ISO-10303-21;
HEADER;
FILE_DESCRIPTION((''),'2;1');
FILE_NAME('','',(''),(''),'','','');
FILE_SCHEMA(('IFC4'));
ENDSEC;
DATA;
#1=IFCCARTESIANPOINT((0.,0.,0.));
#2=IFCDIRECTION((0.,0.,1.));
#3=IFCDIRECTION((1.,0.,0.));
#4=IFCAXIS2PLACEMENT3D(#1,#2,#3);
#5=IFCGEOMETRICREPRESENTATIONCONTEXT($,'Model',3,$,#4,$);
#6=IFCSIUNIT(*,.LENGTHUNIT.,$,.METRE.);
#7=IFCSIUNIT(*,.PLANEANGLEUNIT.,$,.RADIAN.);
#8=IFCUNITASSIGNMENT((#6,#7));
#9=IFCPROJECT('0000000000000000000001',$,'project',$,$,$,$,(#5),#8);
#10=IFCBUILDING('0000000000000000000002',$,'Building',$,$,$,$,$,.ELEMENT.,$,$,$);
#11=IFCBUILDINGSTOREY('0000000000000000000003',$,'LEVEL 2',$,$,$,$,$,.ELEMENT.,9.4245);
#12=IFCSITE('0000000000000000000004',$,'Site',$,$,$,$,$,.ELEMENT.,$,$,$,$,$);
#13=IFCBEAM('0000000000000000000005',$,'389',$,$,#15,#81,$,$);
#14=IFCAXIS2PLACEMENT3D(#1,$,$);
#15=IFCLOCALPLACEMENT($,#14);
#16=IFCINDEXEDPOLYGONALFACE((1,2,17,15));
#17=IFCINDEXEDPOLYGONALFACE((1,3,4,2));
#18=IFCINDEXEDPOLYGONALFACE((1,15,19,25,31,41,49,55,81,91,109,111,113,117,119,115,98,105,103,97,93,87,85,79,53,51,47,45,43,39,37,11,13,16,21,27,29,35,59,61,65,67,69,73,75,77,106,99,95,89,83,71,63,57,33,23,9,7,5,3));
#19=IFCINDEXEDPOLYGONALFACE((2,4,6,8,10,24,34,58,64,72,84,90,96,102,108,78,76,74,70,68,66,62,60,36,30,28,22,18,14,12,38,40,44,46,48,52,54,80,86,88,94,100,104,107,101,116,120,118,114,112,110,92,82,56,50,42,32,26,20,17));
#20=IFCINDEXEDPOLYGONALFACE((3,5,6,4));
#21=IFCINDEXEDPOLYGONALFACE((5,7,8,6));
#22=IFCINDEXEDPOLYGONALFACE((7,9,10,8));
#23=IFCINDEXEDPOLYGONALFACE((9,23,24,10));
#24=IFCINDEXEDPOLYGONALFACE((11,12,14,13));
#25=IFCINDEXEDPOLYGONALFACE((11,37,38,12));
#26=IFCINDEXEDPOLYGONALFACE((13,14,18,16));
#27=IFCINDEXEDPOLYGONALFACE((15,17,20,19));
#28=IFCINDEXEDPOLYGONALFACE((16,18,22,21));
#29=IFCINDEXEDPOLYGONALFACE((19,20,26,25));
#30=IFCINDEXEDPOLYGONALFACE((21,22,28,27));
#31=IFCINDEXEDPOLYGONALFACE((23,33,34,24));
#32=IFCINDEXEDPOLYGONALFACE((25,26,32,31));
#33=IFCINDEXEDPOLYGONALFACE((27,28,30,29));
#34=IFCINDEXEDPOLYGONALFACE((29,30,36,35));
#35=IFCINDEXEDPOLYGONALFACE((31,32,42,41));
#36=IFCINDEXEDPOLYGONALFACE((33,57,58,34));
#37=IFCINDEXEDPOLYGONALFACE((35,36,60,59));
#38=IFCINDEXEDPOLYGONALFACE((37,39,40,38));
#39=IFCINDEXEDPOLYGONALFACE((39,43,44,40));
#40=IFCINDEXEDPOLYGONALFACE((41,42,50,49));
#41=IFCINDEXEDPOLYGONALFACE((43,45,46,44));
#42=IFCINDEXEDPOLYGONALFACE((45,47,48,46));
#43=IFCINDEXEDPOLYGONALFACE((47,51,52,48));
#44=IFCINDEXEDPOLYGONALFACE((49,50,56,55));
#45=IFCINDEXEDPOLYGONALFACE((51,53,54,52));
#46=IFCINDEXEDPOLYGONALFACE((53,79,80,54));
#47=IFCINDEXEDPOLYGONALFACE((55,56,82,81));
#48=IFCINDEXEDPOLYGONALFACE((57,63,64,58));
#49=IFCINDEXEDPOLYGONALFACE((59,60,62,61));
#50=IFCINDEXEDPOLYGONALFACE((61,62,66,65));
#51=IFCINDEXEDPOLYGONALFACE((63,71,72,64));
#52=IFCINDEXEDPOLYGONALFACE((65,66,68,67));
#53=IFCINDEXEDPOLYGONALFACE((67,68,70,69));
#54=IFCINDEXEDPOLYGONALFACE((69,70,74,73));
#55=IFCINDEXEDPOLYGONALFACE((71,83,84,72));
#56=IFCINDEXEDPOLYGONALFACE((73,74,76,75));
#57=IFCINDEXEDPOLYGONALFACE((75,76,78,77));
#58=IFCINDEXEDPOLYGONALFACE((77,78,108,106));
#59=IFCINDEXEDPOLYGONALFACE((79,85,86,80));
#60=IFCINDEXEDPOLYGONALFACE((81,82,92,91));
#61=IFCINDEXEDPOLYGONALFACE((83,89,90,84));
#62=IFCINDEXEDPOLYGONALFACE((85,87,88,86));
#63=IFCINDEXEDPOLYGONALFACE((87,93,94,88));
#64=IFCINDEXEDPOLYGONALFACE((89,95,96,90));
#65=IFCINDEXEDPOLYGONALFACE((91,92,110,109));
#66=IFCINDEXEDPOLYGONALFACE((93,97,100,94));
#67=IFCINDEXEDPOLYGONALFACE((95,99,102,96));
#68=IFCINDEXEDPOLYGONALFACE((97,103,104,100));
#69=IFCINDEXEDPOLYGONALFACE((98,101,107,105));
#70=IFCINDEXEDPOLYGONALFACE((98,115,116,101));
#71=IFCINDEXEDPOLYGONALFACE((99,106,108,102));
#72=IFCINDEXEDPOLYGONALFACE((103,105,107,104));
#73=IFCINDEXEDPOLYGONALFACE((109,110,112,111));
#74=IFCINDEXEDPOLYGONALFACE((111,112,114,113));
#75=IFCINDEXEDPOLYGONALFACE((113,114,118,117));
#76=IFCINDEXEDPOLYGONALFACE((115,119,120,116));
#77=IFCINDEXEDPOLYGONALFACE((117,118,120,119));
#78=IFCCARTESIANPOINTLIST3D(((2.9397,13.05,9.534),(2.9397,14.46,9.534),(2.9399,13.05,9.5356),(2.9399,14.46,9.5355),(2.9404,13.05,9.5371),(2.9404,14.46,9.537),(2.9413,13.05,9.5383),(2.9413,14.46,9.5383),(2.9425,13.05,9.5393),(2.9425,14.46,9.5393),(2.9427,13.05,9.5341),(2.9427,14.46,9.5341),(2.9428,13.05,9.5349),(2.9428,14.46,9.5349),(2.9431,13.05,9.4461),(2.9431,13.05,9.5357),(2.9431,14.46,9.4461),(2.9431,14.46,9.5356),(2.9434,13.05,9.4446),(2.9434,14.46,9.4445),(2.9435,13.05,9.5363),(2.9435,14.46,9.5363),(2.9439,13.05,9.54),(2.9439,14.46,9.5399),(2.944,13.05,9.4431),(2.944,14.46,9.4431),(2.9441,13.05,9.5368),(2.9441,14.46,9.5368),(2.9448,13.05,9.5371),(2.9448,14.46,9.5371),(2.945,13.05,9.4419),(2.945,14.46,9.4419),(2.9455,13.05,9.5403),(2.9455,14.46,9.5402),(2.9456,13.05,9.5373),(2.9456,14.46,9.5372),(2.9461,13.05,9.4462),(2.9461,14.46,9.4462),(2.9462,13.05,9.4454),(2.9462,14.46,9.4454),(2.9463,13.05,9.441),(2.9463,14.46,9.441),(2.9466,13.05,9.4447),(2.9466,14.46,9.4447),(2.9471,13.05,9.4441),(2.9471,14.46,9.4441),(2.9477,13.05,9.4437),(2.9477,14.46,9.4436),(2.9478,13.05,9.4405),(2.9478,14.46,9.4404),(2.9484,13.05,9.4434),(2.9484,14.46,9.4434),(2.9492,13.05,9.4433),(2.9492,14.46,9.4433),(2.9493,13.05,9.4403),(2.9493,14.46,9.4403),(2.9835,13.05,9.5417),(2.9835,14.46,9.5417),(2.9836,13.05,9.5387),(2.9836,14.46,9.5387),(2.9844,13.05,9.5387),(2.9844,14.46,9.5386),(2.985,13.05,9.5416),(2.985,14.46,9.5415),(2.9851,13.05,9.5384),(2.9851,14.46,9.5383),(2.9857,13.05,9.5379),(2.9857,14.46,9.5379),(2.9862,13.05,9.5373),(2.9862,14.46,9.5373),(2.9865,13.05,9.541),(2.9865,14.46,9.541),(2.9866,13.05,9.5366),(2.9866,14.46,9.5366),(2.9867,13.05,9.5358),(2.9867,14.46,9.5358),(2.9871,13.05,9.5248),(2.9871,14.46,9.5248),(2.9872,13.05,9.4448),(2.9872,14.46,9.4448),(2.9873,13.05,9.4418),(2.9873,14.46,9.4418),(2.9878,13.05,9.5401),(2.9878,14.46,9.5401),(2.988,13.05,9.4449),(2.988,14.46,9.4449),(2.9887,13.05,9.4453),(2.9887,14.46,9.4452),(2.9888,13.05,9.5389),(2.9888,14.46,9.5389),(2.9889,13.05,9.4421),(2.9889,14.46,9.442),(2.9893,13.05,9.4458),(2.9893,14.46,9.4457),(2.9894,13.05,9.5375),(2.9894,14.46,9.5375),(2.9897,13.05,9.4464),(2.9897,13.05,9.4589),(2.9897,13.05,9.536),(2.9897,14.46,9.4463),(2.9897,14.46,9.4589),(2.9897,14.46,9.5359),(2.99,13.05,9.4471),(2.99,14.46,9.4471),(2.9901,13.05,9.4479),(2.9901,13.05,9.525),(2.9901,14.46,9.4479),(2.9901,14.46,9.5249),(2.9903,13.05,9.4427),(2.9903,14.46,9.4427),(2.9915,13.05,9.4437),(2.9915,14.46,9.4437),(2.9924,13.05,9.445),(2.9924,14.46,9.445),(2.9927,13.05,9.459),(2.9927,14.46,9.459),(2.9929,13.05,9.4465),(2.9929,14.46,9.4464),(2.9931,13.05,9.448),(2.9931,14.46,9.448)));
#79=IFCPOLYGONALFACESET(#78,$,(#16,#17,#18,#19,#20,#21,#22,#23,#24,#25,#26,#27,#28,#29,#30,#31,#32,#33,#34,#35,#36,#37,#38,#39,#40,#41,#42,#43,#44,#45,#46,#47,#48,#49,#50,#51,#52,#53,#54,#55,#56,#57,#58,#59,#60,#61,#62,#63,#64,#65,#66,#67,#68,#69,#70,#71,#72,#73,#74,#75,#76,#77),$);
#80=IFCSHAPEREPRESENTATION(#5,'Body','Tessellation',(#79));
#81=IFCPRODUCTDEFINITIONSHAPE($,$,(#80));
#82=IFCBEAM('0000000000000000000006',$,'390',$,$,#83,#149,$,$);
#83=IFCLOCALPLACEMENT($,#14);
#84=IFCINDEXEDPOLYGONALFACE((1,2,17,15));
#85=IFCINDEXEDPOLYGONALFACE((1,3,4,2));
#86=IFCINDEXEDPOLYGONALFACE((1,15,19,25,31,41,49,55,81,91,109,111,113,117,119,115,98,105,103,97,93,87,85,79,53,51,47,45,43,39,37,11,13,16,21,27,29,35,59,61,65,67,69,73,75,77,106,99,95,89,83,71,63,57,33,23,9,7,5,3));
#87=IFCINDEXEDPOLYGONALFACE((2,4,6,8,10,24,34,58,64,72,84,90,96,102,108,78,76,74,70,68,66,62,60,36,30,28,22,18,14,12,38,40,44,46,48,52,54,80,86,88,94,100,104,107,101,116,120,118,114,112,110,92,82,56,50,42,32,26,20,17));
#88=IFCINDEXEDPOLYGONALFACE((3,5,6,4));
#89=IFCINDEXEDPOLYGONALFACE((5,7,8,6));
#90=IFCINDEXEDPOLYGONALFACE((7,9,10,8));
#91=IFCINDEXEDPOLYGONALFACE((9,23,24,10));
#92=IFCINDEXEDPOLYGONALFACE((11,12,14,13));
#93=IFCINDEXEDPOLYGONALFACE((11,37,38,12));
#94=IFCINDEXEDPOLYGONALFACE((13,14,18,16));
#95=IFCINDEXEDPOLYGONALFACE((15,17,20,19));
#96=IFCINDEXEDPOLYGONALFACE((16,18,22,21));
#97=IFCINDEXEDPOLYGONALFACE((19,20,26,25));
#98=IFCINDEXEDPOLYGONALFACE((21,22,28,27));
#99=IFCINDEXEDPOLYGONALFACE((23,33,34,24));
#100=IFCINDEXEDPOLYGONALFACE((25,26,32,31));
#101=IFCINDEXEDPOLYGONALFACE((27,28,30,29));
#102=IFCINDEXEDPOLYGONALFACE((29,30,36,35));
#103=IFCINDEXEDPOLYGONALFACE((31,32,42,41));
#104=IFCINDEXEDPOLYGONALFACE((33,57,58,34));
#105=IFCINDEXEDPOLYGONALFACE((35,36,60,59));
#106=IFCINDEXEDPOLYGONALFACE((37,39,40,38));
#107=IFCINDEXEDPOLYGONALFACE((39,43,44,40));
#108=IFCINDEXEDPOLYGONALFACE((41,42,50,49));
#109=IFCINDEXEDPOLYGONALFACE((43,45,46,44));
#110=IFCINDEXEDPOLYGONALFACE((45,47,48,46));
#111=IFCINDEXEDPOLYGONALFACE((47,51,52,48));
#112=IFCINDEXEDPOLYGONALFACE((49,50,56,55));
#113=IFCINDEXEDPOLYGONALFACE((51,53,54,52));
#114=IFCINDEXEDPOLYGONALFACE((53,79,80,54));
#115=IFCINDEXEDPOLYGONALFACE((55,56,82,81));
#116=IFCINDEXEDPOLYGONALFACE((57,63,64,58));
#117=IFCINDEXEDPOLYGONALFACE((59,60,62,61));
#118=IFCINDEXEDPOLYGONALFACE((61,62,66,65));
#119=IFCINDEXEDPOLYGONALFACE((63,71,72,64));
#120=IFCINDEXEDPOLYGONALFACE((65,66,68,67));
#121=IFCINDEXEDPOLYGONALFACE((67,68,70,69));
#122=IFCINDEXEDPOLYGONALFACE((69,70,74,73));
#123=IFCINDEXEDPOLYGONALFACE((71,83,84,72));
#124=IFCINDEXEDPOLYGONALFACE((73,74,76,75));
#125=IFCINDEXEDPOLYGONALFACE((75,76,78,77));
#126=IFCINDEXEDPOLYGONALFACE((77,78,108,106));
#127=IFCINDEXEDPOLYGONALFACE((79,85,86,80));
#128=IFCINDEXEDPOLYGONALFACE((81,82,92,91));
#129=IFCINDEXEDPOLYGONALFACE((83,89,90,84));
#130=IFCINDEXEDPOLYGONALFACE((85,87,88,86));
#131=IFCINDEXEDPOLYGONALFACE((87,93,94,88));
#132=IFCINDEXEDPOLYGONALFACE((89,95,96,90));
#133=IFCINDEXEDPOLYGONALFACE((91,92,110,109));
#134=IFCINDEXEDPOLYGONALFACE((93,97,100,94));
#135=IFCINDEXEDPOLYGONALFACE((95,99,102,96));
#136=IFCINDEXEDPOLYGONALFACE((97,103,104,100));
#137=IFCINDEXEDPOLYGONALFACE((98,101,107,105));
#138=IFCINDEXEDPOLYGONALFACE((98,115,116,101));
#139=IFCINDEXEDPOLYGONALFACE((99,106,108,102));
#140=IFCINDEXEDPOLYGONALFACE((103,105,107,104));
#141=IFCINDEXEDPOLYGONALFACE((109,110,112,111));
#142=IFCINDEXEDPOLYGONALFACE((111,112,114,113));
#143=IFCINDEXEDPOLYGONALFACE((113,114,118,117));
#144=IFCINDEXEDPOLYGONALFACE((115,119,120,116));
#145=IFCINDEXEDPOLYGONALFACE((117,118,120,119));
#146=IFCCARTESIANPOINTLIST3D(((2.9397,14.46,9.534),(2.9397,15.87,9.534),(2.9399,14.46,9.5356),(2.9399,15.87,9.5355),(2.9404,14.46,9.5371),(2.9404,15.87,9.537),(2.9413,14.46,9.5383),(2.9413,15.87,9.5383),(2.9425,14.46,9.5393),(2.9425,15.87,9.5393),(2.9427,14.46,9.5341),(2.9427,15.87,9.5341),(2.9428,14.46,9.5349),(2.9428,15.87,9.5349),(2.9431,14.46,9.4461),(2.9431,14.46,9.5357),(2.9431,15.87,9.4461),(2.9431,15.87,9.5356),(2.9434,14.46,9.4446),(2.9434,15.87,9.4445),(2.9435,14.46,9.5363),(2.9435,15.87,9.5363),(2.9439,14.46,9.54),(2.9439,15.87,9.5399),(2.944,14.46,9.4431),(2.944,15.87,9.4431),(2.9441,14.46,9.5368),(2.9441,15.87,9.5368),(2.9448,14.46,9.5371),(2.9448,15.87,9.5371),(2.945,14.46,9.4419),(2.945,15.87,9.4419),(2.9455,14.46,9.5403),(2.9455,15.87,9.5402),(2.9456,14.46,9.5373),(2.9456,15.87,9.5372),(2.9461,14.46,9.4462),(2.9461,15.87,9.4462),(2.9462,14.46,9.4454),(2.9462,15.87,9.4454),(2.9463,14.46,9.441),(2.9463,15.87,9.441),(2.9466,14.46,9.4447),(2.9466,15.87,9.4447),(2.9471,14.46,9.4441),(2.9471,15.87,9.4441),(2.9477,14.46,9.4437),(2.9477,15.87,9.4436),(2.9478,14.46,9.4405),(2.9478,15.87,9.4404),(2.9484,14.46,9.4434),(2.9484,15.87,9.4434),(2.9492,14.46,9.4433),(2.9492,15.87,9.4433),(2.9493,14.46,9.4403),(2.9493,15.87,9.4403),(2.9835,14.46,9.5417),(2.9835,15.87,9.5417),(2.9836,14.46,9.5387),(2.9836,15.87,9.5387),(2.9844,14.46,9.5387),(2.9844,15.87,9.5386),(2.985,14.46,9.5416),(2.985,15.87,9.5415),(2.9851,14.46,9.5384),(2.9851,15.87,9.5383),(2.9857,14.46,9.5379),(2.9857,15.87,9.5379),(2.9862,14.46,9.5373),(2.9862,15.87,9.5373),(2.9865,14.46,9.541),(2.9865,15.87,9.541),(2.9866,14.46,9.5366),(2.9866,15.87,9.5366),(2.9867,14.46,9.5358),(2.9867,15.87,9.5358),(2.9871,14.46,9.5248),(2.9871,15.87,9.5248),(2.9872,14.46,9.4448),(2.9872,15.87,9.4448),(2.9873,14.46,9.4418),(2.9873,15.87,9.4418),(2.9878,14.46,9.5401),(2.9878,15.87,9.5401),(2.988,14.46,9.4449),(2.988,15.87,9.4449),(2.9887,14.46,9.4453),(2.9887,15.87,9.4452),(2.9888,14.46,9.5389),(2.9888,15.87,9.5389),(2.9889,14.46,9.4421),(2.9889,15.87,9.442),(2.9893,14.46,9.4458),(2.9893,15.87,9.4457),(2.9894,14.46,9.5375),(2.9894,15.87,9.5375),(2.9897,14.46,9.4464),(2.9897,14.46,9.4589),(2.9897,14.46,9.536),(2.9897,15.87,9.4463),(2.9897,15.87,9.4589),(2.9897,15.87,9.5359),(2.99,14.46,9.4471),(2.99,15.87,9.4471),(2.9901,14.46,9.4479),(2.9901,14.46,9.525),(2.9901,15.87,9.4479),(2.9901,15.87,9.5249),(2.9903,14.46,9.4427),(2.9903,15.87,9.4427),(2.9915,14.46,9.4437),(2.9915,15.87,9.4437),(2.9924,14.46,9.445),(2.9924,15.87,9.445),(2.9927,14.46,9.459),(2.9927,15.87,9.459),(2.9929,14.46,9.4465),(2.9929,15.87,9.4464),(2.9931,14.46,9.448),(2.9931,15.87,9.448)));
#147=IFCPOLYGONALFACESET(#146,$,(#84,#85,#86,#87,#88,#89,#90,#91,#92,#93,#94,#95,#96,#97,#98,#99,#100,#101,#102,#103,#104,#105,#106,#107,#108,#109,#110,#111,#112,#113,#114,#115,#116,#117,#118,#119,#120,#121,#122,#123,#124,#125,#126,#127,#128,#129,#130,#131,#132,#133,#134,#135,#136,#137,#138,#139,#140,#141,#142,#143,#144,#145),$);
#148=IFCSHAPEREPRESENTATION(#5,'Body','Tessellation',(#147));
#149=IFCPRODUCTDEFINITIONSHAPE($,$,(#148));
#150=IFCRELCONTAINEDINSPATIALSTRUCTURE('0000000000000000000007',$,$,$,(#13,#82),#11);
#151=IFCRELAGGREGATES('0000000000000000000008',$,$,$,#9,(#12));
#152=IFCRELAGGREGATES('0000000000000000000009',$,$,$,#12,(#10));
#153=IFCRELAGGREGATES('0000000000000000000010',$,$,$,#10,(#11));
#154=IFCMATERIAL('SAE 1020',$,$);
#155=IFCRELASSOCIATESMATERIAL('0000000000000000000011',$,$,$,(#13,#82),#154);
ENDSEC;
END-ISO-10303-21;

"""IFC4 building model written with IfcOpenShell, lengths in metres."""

from ifc_helpers import new_model, si_unit, frame, origin_with_axes, origin_2d_with_axis, place, context, project, spatial, c_section, extrude, material, material_profile, profile_set, profile_usage, element, save


model = new_model("IFC4")

# Units and contexts
model_context = context("Model", 3, world=origin_with_axes())
ifc_project = project(units=[si_unit("LENGTHUNIT", "METRE"), si_unit("PLANEANGLEUNIT", "RADIAN")], contexts=[model_context])

# Site, building, storey
site = spatial("IfcSite", under=ifc_project, Name="Site", CompositionType="ELEMENT")
building = spatial("IfcBuilding", under=site, Name="Building", CompositionType="ELEMENT")
storey = spatial("IfcBuildingStorey", under=building, Name="LEVEL 2", CompositionType="ELEMENT", Elevation=9.4245)

# Beams
ifc_material = material(Name="SAE 1020")
ifc_material_profile_1 = material_profile(ifc_material, c_section(Depth=0.1, Width=0.05, WallThickness=0.003, Girth=0.017, InternalFilletRadius=0.003, at=origin_2d_with_axis()))
ifc_profile_set_1 = profile_set([ifc_material_profile_1])
ifc_profile_usage_1 = profile_usage(ifc_profile_set_1, cardinal=10)
beam_1_placement = place(None, frame((2.9664, 13.05, 9.491), z_axis=(0.0, 1.0, -0.00003), x_axis=(0.999256, 0.000001, 0.038562)))
element("IfcBeam", 1, at=beam_1_placement, inside=storey, material=ifc_profile_usage_1, Name="389", context=model_context, shape_type="SweptSolid", body=[
    extrude(c_section(Depth=0.1, Width=0.05, WallThickness=0.003, Girth=0.017, InternalFilletRadius=0.003, at=origin_2d_with_axis()), origin_with_axes(), (0.0, 0.0, 1.0), 1.41),
])
ifc_material_profile_2 = material_profile(ifc_material, c_section(Depth=0.1, Width=0.05, WallThickness=0.003, Girth=0.017, InternalFilletRadius=0.003, at=origin_2d_with_axis()))
ifc_profile_set_2 = profile_set([ifc_material_profile_2])
ifc_profile_usage_2 = profile_usage(ifc_profile_set_2, cardinal=10)
beam_2_placement = place(None, frame((2.9664, 14.46, 9.491), z_axis=(0.0, 1.0, -0.00003), x_axis=(0.999256, 0.000001, 0.038562)))
element("IfcBeam", 2, at=beam_2_placement, inside=storey, material=ifc_profile_usage_2, Name="390", context=model_context, shape_type="SweptSolid", body=[
    extrude(c_section(Depth=0.1, Width=0.05, WallThickness=0.003, Girth=0.017, InternalFilletRadius=0.003, at=origin_2d_with_axis()), origin_with_axes(), (0.0, 0.0, 1.0), 1.41),
])

save(model, "model.ifc")
